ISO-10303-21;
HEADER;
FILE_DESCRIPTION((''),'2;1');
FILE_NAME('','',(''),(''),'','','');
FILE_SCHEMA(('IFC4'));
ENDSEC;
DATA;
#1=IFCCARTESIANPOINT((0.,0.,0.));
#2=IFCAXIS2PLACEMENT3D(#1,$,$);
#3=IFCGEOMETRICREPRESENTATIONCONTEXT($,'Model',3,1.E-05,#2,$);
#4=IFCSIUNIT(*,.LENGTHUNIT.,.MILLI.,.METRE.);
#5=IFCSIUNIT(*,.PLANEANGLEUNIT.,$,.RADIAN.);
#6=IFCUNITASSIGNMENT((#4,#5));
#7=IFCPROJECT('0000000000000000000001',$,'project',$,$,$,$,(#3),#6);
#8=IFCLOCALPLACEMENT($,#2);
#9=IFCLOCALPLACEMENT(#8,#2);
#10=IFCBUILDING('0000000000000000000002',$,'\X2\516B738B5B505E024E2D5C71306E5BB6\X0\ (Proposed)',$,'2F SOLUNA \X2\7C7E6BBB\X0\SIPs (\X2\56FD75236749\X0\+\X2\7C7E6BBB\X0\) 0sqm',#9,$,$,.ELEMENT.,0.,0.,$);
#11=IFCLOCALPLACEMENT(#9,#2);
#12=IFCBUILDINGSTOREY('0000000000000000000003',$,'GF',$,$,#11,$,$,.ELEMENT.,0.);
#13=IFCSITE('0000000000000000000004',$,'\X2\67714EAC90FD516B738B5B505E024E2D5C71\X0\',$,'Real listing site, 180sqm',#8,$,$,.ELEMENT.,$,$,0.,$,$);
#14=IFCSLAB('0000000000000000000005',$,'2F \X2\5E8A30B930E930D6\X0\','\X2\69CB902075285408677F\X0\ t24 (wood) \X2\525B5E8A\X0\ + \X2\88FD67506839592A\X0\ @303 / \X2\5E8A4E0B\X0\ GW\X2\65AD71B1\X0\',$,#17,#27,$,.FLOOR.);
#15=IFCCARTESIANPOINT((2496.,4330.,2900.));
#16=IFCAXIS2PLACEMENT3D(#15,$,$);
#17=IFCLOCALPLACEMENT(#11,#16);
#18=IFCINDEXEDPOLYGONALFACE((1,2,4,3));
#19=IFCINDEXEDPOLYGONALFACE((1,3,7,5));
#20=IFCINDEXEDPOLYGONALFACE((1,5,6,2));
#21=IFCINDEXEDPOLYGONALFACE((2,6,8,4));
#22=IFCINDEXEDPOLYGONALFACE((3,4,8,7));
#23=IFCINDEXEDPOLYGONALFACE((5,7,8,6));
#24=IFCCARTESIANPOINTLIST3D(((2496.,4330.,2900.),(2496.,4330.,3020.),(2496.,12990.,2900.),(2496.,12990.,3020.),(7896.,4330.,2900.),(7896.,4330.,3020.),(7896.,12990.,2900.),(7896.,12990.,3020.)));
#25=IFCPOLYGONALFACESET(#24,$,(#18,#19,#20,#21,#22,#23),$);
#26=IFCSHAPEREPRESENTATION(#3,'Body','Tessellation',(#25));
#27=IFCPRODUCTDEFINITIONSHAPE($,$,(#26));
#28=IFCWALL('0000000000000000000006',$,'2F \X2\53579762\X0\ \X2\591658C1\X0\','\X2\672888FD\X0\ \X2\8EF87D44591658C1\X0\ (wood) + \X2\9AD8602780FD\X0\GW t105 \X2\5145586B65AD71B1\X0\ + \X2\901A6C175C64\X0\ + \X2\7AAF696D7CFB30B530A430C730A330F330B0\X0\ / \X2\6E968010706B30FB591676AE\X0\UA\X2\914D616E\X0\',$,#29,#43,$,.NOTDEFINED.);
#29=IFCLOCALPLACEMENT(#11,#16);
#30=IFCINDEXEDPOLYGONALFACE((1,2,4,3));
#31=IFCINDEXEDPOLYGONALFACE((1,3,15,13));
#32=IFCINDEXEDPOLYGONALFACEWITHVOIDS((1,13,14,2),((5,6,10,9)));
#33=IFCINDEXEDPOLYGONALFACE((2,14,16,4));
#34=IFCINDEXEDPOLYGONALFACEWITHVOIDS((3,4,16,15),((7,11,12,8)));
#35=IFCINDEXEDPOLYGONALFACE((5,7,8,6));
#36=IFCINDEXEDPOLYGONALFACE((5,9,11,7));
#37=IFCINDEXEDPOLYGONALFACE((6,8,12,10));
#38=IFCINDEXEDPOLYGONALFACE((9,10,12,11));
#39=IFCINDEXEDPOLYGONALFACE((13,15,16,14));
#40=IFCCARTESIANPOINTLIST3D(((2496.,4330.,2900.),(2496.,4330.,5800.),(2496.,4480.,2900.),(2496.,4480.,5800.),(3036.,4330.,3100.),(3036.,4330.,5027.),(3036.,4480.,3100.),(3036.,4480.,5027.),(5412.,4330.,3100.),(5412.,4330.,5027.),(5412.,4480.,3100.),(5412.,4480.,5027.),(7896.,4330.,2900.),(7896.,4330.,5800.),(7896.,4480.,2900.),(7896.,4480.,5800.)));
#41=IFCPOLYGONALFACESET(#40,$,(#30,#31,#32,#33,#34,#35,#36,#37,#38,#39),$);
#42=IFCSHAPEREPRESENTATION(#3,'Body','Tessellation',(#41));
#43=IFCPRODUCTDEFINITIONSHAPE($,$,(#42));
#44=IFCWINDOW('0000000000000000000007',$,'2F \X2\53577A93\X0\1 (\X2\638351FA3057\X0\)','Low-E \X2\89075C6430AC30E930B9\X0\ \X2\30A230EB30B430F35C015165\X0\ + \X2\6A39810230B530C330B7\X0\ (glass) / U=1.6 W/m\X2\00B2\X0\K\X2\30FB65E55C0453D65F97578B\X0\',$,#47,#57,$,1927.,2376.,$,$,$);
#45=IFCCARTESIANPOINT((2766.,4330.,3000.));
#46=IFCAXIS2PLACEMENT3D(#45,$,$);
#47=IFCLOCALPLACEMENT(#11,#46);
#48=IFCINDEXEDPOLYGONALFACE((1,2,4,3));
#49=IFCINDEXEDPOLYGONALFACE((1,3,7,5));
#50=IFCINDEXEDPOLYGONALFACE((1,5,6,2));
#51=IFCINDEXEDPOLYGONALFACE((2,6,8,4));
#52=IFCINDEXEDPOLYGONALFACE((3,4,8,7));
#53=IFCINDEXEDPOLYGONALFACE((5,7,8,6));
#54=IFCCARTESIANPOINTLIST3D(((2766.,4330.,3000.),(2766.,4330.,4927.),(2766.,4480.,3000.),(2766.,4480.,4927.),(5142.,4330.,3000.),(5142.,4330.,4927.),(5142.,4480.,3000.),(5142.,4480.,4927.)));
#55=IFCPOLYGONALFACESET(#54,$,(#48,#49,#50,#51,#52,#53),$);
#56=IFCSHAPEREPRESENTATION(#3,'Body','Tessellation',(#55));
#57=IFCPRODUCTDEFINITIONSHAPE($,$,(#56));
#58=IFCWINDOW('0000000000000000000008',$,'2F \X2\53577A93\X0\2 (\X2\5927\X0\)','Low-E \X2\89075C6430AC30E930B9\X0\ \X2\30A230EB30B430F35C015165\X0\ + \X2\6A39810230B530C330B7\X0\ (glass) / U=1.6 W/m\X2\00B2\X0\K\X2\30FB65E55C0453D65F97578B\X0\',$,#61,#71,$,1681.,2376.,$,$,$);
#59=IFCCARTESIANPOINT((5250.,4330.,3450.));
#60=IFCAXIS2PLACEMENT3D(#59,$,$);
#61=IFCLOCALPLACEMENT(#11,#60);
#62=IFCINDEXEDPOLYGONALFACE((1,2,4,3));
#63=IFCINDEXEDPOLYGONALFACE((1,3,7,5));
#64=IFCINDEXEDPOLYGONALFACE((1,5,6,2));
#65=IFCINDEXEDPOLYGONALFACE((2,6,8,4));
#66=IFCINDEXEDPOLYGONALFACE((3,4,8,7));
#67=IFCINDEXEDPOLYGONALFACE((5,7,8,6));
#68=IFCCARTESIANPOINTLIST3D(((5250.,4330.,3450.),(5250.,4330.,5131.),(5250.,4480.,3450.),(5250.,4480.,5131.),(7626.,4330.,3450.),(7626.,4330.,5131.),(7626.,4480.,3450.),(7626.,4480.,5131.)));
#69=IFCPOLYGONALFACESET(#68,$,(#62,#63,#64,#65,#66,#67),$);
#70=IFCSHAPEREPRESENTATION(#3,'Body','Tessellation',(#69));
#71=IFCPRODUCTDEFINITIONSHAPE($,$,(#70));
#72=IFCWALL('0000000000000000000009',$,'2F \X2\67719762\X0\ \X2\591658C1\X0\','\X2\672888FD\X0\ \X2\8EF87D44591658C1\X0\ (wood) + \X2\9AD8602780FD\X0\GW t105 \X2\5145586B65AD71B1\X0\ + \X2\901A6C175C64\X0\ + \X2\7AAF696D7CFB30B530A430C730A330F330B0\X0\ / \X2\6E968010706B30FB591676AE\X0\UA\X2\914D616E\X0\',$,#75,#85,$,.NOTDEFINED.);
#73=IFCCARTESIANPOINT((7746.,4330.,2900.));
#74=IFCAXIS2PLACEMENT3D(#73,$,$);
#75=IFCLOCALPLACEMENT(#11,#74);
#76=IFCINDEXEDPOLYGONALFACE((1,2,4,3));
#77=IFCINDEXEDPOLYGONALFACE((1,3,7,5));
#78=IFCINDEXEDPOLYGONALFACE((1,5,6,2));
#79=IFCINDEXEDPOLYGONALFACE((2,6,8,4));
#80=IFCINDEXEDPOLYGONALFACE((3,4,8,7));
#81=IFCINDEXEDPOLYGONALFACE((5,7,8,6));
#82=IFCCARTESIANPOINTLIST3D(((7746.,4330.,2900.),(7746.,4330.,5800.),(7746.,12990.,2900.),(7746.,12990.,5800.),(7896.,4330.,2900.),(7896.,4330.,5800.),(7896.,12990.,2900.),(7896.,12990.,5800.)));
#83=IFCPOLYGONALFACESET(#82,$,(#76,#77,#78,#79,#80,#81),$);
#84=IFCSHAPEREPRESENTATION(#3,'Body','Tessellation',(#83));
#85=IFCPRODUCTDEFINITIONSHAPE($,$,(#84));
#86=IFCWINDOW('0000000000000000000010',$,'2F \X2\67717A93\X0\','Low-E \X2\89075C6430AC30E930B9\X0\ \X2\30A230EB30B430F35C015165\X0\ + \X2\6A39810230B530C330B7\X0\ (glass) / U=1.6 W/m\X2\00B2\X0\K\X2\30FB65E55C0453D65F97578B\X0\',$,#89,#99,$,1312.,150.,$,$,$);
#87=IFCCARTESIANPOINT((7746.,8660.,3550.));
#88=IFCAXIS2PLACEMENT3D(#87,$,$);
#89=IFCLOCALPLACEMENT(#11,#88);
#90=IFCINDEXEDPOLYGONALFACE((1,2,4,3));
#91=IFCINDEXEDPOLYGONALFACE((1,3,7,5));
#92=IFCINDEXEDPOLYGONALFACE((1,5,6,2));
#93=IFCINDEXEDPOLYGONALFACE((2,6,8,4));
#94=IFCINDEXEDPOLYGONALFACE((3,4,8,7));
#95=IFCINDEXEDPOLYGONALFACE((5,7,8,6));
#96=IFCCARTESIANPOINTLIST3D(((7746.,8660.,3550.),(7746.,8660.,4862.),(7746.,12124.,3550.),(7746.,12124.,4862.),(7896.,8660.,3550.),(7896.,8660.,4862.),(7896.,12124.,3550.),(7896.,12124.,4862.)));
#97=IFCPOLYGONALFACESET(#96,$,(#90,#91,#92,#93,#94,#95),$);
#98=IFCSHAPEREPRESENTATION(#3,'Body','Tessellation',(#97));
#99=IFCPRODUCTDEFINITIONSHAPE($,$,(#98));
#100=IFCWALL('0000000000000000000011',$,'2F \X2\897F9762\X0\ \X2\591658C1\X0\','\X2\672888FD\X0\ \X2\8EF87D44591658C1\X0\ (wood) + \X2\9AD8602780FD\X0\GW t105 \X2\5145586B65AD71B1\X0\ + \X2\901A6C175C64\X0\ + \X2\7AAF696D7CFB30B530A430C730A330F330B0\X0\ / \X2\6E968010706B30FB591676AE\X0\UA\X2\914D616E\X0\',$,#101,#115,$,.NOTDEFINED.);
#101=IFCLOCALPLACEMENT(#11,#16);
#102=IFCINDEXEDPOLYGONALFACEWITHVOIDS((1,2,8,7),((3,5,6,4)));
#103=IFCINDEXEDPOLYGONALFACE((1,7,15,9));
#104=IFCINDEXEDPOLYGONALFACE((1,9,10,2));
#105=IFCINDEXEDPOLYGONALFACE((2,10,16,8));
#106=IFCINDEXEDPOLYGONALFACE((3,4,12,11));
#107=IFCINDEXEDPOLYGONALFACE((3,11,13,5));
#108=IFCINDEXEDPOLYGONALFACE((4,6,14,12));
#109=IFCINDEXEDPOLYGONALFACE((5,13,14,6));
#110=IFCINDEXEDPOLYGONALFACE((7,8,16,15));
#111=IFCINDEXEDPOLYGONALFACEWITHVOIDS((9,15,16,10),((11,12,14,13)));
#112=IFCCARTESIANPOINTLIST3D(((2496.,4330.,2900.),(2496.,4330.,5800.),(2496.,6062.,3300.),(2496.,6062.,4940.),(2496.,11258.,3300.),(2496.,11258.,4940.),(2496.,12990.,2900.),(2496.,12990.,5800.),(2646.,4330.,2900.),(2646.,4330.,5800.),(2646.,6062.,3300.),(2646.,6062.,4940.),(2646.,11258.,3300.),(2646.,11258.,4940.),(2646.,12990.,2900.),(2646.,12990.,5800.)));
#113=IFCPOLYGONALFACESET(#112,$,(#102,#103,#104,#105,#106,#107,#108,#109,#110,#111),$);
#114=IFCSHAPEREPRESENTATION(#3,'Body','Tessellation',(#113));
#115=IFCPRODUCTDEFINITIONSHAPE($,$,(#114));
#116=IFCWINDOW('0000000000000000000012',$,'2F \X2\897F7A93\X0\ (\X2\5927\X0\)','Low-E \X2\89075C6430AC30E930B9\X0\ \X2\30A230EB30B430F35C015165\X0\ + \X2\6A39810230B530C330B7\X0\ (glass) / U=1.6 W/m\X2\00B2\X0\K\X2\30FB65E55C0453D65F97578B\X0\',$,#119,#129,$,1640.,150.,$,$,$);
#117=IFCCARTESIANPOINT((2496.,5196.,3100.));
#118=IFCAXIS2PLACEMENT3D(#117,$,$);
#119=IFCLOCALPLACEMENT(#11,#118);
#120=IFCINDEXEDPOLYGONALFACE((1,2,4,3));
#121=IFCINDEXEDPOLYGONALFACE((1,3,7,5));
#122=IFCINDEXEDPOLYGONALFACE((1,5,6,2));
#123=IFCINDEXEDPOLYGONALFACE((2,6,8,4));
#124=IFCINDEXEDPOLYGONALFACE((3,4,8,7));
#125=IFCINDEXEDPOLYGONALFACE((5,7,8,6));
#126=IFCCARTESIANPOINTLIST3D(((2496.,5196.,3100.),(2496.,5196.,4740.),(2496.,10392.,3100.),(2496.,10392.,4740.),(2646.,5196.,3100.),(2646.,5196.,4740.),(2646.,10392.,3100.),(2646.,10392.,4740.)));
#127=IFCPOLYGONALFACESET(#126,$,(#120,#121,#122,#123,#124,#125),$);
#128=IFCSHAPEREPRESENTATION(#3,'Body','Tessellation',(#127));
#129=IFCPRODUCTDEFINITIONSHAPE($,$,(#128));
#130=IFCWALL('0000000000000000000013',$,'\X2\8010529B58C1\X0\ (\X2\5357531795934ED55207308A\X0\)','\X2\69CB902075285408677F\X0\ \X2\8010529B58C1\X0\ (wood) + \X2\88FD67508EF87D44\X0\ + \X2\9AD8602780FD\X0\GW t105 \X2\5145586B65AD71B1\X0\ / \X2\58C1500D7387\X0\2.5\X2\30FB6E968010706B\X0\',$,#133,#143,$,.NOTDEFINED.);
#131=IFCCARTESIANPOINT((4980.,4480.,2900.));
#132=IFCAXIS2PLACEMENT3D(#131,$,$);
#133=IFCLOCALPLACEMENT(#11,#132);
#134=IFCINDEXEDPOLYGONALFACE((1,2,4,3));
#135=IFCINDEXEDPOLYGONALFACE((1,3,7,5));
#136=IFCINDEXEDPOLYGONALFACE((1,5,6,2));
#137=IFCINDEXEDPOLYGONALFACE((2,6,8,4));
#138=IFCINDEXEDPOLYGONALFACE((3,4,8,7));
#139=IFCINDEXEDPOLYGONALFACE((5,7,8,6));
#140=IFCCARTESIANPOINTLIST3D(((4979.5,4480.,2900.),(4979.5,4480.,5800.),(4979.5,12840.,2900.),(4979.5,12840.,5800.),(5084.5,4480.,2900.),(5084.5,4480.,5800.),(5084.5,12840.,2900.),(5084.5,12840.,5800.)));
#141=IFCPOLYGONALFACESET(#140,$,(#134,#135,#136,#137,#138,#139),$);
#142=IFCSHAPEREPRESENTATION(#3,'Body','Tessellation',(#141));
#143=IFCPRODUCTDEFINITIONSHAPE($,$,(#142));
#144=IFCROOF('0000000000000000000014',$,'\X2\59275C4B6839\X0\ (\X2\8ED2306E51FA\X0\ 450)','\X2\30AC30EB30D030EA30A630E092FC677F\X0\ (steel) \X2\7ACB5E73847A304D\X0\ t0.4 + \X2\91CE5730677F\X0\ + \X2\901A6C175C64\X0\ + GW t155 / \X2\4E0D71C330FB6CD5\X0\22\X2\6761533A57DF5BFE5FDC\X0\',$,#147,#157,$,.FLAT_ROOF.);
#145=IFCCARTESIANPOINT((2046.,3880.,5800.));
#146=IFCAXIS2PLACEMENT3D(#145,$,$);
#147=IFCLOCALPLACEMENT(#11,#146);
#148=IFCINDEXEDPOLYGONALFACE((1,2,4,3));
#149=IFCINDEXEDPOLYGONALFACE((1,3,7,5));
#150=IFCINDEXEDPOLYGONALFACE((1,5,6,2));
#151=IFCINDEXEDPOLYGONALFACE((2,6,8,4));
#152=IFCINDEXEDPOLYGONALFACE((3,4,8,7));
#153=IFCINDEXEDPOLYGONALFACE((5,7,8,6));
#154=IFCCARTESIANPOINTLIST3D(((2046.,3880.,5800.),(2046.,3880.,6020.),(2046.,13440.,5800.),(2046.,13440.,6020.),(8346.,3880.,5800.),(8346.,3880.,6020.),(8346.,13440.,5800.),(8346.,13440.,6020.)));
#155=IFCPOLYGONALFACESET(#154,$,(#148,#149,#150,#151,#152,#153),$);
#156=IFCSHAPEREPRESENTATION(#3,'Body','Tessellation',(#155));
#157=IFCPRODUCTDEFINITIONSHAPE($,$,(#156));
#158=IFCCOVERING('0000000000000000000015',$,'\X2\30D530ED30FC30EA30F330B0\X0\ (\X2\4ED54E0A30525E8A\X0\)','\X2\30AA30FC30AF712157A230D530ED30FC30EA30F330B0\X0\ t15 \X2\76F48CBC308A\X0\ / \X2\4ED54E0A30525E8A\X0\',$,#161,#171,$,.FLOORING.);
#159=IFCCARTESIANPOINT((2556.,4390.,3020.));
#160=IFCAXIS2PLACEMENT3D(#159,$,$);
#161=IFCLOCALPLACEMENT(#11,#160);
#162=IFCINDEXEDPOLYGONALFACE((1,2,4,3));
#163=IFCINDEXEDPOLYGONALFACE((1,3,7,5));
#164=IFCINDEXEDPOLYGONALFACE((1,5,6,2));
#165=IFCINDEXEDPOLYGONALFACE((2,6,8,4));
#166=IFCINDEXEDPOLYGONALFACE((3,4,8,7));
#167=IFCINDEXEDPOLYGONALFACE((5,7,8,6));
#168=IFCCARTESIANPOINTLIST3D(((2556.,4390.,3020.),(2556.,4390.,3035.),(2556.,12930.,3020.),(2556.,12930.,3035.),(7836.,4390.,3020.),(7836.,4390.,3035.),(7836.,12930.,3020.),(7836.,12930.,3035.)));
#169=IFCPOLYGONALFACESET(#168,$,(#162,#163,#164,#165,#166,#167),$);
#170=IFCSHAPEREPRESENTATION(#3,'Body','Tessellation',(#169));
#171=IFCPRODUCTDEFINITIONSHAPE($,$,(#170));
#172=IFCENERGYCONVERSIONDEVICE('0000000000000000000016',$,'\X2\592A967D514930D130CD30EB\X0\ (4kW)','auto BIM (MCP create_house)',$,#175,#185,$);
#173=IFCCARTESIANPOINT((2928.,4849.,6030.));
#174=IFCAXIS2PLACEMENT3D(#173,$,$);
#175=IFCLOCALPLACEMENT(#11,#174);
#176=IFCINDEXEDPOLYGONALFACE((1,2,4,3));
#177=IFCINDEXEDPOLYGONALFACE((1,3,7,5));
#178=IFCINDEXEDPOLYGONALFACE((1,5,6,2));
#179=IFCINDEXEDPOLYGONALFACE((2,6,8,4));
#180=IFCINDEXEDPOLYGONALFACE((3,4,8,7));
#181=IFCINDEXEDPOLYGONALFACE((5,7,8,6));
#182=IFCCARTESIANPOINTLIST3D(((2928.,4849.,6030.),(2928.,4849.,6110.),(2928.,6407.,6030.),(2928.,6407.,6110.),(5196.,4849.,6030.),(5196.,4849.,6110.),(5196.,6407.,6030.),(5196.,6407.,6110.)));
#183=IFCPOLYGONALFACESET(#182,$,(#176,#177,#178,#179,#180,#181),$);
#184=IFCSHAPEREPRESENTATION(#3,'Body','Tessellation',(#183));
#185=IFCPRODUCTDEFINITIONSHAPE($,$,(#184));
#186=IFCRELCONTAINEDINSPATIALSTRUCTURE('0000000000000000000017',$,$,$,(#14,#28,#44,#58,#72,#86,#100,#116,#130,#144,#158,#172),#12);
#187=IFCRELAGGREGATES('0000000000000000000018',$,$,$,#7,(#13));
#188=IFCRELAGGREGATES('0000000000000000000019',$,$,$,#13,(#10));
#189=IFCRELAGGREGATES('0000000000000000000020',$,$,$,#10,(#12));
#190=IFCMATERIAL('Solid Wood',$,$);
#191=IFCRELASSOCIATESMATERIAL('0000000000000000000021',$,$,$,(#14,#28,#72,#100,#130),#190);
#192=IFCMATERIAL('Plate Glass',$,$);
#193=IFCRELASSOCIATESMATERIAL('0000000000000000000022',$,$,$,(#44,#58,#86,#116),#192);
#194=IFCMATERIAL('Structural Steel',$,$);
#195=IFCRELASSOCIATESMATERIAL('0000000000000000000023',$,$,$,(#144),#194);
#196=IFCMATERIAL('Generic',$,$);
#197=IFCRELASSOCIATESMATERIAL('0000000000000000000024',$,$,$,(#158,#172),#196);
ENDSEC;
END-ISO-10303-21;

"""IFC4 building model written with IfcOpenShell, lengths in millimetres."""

from ifc_helpers import new_model, si_unit, frame, frame_2d, origin, place, context, project, spatial, rectangle, extrude, material, element, fill, save


model = new_model("IFC4")

# Units and contexts
model_context = context("Model", 3, precision=1e-05, world=origin())
ifc_project = project(units=[si_unit("LENGTHUNIT", "METRE", prefix="MILLI"), si_unit("PLANEANGLEUNIT", "RADIAN")], contexts=[model_context])

# Site, building, storey
site_placement = place(None, origin())
site = spatial("IfcSite", under=ifc_project, at=site_placement, Name="東京都八王子市中山", ObjectType="Real listing site, 180sqm", CompositionType="ELEMENT", RefElevation=0.0)
building_placement = place(site_placement, origin())
building = spatial("IfcBuilding", under=site, at=building_placement, Name="八王子市中山の家 (Proposed)", ObjectType="2F SOLUNA 籾殻SIPs (国産杉+籾殻) 0sqm", CompositionType="ELEMENT", ElevationOfRefHeight=0.0, ElevationOfTerrain=0.0)
storey_placement = place(building_placement, origin())
storey = spatial("IfcBuildingStorey", under=building, at=storey_placement, Name="GF", CompositionType="ELEMENT", Elevation=0.0)

# Slab
ifc_material_1 = material(Name="Solid Wood")
slab_placement = place(storey_placement, frame((2496.0, 4330.0, 2900.0)))
element("IfcSlab", 1, at=slab_placement, inside=storey, material=ifc_material_1, Name="2F 床スラブ", Description="構造用合板 t24 (wood) 剛床 + 製材根太 @303 / 床下 GW断熱", PredefinedType="FLOOR", context=model_context, shape_type="SweptSolid", body=[
    extrude(rectangle(XDim=5400.0, YDim=8660.0, at=frame_2d((2700.0, 4330.0))), frame((2496.0, 4330.0, 2900.0)), (0.0, 0.0, 1.0), 120.0),
])

# Wall, openings, windows
wall_1_placement = place(storey_placement, frame((2496.0, 4330.0, 2900.0)))
wall_1 = element("IfcWall", 2, at=wall_1_placement, inside=storey, material=ifc_material_1, Name="2F 南面 外壁", Description="木製 軸組外壁 (wood) + 高性能GW t105 充填断熱 + 通気層 + 窯業系サイディング / 準耐火・外皮UA配慮", PredefinedType="NOTDEFINED", context=model_context, shape_type="SweptSolid", body=[
    extrude(rectangle(XDim=5400.0, YDim=150.0, at=frame_2d((2700.0, 75.0))), frame((2496.0, 4330.0, 2900.0)), (0.0, 0.0, 1.0), 2900.0),
])
opening_1_placement = place(storey_placement, frame((2766.0, 4330.0, 3000.0)))
opening_1 = element("IfcOpeningElement", 3, at=opening_1_placement, cuts=wall_1, PredefinedType="NOTDEFINED", context=model_context, shape_type="SweptSolid", body=[
    extrude(rectangle(XDim=2376.0, YDim=150.0, at=frame_2d((1188.0, 75.0))), frame((2766.0, 4330.0, 3000.0)), (0.0, 0.0, 1.0), 1927.0),
])
opening_2_placement = place(storey_placement, frame((5250.0, 4330.0, 3450.0)))
opening_2 = element("IfcOpeningElement", 4, at=opening_2_placement, cuts=wall_1, PredefinedType="NOTDEFINED", context=model_context, shape_type="SweptSolid", body=[
    extrude(rectangle(XDim=2376.0, YDim=150.0, at=frame_2d((1188.0, 75.0))), frame((5250.0, 4330.0, 3450.0)), (0.0, 0.0, 1.0), 1681.0),
])
ifc_material_2 = material(Name="Plate Glass")
window_1_placement = place(storey_placement, frame((2766.0, 4330.0, 3000.0)))
window_1 = element("IfcWindow", 5, at=window_1_placement, inside=storey, material=ifc_material_2, Name="2F 南窓1 (掃出し)", Description="Low-E 複層ガラス アルゴン封入 + 樹脂サッシ (glass) / U=1.6 W/m²K・日射取得型", OverallHeight=1927.0, OverallWidth=2376.0, context=model_context, shape_type="SweptSolid", body=[
    extrude(rectangle(XDim=2376.0, YDim=150.0, at=frame_2d((1188.0, 75.0))), frame((2766.0, 4330.0, 3000.0)), (0.0, 0.0, 1.0), 1927.0),
])
fill(opening_1, window_1)
window_2_placement = place(storey_placement, frame((5250.0, 4330.0, 3450.0)))
window_2 = element("IfcWindow", 6, at=window_2_placement, inside=storey, material=ifc_material_2, Name="2F 南窓2 (大)", Description="Low-E 複層ガラス アルゴン封入 + 樹脂サッシ (glass) / U=1.6 W/m²K・日射取得型", OverallHeight=1681.0, OverallWidth=2376.0, context=model_context, shape_type="SweptSolid", body=[
    extrude(rectangle(XDim=2376.0, YDim=150.0, at=frame_2d((1188.0, 75.0))), frame((5250.0, 4330.0, 3450.0)), (0.0, 0.0, 1.0), 1681.0),
])
fill(opening_2, window_2)

# Walls, openings, windows
wall_2_placement = place(storey_placement, frame((7746.0, 4330.0, 2900.0)))
wall_2 = element("IfcWall", 7, at=wall_2_placement, inside=storey, material=ifc_material_1, Name="2F 東面 外壁", Description="木製 軸組外壁 (wood) + 高性能GW t105 充填断熱 + 通気層 + 窯業系サイディング / 準耐火・外皮UA配慮", PredefinedType="NOTDEFINED", context=model_context, shape_type="SweptSolid", body=[
    extrude(rectangle(XDim=150.0, YDim=8660.0, at=frame_2d((75.0, 4330.0))), frame((7746.0, 4330.0, 2900.0)), (0.0, 0.0, 1.0), 2900.0),
])
opening_3_placement = place(storey_placement, frame((7746.0, 8660.0, 3550.0)))
opening_3 = element("IfcOpeningElement", 8, at=opening_3_placement, cuts=wall_2, PredefinedType="NOTDEFINED", context=model_context, shape_type="SweptSolid", body=[
    extrude(rectangle(XDim=150.0, YDim=3464.0, at=frame_2d((75.0, 1732.0))), frame((7746.0, 8660.0, 3550.0)), (0.0, 0.0, 1.0), 1312.0),
])
window_3_placement = place(storey_placement, frame((7746.0, 8660.0, 3550.0)))
window_3 = element("IfcWindow", 9, at=window_3_placement, inside=storey, material=ifc_material_2, Name="2F 東窓", Description="Low-E 複層ガラス アルゴン封入 + 樹脂サッシ (glass) / U=1.6 W/m²K・日射取得型", OverallHeight=1312.0, OverallWidth=150.0, context=model_context, shape_type="SweptSolid", body=[
    extrude(rectangle(XDim=150.0, YDim=3464.0, at=frame_2d((75.0, 1732.0))), frame((7746.0, 8660.0, 3550.0)), (0.0, 0.0, 1.0), 1312.0),
])
fill(opening_3, window_3)
wall_3_placement = place(storey_placement, frame((2496.0, 4330.0, 2900.0)))
wall_3 = element("IfcWall", 10, at=wall_3_placement, inside=storey, material=ifc_material_1, Name="2F 西面 外壁", Description="木製 軸組外壁 (wood) + 高性能GW t105 充填断熱 + 通気層 + 窯業系サイディング / 準耐火・外皮UA配慮", PredefinedType="NOTDEFINED", context=model_context, shape_type="SweptSolid", body=[
    extrude(rectangle(XDim=150.0, YDim=8660.0, at=frame_2d((75.0, 4330.0))), frame((2496.0, 4330.0, 2900.0)), (0.0, 0.0, 1.0), 2900.0),
])
opening_4_placement = place(storey_placement, frame((2496.0, 5196.0, 3100.0)))
opening_4 = element("IfcOpeningElement", 11, at=opening_4_placement, cuts=wall_3, PredefinedType="NOTDEFINED", context=model_context, shape_type="SweptSolid", body=[
    extrude(rectangle(XDim=150.0, YDim=5196.0, at=frame_2d((75.0, 2598.0))), frame((2496.0, 5196.0, 3100.0)), (0.0, 0.0, 1.0), 1640.0),
])
window_4_placement = place(storey_placement, frame((2496.0, 5196.0, 3100.0)))
window_4 = element("IfcWindow", 12, at=window_4_placement, inside=storey, material=ifc_material_2, Name="2F 西窓 (大)", Description="Low-E 複層ガラス アルゴン封入 + 樹脂サッシ (glass) / U=1.6 W/m²K・日射取得型", OverallHeight=1640.0, OverallWidth=150.0, context=model_context, shape_type="SweptSolid", body=[
    extrude(rectangle(XDim=150.0, YDim=5196.0, at=frame_2d((75.0, 2598.0))), frame((2496.0, 5196.0, 3100.0)), (0.0, 0.0, 1.0), 1640.0),
])
fill(opening_4, window_4)

# Wall
wall_4_placement = place(storey_placement, frame((4980.0, 4480.0, 2900.0)))
element("IfcWall", 13, at=wall_4_placement, inside=storey, material=ifc_material_1, Name="耐力壁 (南北間仕切り)", Description="構造用合板 耐力壁 (wood) + 製材軸組 + 高性能GW t105 充填断熱 / 壁倍率2.5・準耐火", PredefinedType="NOTDEFINED", context=model_context, shape_type="SweptSolid", body=[
    extrude(rectangle(XDim=105.0, YDim=8360.0, at=frame_2d((52.0, 4180.0))), frame((4980.0, 4480.0, 2900.0)), (0.0, 0.0, 1.0), 2900.0),
])

# Roof
ifc_material_3 = material(Name="Structural Steel")
roof_placement = place(storey_placement, frame((2046.0, 3880.0, 5800.0)))
element("IfcRoof", 14, at=roof_placement, inside=storey, material=ifc_material_3, Name="大屋根 (軒の出 450)", Description="ガルバリウム鋼板 (steel) 立平葺き t0.4 + 野地板 + 通気層 + GW t155 / 不燃・法22条区域対応", PredefinedType="FLAT_ROOF", context=model_context, shape_type="SweptSolid", body=[
    extrude(rectangle(XDim=6300.0, YDim=9560.0, at=frame_2d((3150.0, 4780.0))), frame((2046.0, 3880.0, 5800.0)), (0.0, 0.0, 1.0), 220.0),
])

# Covering
ifc_material_4 = material(Name="Generic")
covering_placement = place(storey_placement, frame((2556.0, 4390.0, 3020.0)))
element("IfcCovering", 15, at=covering_placement, inside=storey, material=ifc_material_4, Name="フローリング (仕上げ床)", Description="オーク無垢フローリング t15 直貼り / 仕上げ床", PredefinedType="FLOORING", context=model_context, shape_type="SweptSolid", body=[
    extrude(rectangle(XDim=5280.0, YDim=8540.0, at=frame_2d((2640.0, 4270.0))), frame((2556.0, 4390.0, 3020.0)), (0.0, 0.0, 1.0), 15.0),
])

# Energy conversion device
energy_conversion_device_placement = place(storey_placement, frame((2928.0, 4849.0, 6030.0)))
element("IfcEnergyConversionDevice", 16, at=energy_conversion_device_placement, inside=storey, material=ifc_material_4, Name="太陽光パネル (4kW)", Description="auto BIM (MCP create_house)", context=model_context, shape_type="SweptSolid", body=[
    extrude(rectangle(XDim=2268.0, YDim=1558.0, at=frame_2d((1134.0, 779.0))), frame((2928.0, 4849.0, 6030.0)), (0.0, 0.0, 1.0), 80.0),
])

save(model, "model.ifc")
